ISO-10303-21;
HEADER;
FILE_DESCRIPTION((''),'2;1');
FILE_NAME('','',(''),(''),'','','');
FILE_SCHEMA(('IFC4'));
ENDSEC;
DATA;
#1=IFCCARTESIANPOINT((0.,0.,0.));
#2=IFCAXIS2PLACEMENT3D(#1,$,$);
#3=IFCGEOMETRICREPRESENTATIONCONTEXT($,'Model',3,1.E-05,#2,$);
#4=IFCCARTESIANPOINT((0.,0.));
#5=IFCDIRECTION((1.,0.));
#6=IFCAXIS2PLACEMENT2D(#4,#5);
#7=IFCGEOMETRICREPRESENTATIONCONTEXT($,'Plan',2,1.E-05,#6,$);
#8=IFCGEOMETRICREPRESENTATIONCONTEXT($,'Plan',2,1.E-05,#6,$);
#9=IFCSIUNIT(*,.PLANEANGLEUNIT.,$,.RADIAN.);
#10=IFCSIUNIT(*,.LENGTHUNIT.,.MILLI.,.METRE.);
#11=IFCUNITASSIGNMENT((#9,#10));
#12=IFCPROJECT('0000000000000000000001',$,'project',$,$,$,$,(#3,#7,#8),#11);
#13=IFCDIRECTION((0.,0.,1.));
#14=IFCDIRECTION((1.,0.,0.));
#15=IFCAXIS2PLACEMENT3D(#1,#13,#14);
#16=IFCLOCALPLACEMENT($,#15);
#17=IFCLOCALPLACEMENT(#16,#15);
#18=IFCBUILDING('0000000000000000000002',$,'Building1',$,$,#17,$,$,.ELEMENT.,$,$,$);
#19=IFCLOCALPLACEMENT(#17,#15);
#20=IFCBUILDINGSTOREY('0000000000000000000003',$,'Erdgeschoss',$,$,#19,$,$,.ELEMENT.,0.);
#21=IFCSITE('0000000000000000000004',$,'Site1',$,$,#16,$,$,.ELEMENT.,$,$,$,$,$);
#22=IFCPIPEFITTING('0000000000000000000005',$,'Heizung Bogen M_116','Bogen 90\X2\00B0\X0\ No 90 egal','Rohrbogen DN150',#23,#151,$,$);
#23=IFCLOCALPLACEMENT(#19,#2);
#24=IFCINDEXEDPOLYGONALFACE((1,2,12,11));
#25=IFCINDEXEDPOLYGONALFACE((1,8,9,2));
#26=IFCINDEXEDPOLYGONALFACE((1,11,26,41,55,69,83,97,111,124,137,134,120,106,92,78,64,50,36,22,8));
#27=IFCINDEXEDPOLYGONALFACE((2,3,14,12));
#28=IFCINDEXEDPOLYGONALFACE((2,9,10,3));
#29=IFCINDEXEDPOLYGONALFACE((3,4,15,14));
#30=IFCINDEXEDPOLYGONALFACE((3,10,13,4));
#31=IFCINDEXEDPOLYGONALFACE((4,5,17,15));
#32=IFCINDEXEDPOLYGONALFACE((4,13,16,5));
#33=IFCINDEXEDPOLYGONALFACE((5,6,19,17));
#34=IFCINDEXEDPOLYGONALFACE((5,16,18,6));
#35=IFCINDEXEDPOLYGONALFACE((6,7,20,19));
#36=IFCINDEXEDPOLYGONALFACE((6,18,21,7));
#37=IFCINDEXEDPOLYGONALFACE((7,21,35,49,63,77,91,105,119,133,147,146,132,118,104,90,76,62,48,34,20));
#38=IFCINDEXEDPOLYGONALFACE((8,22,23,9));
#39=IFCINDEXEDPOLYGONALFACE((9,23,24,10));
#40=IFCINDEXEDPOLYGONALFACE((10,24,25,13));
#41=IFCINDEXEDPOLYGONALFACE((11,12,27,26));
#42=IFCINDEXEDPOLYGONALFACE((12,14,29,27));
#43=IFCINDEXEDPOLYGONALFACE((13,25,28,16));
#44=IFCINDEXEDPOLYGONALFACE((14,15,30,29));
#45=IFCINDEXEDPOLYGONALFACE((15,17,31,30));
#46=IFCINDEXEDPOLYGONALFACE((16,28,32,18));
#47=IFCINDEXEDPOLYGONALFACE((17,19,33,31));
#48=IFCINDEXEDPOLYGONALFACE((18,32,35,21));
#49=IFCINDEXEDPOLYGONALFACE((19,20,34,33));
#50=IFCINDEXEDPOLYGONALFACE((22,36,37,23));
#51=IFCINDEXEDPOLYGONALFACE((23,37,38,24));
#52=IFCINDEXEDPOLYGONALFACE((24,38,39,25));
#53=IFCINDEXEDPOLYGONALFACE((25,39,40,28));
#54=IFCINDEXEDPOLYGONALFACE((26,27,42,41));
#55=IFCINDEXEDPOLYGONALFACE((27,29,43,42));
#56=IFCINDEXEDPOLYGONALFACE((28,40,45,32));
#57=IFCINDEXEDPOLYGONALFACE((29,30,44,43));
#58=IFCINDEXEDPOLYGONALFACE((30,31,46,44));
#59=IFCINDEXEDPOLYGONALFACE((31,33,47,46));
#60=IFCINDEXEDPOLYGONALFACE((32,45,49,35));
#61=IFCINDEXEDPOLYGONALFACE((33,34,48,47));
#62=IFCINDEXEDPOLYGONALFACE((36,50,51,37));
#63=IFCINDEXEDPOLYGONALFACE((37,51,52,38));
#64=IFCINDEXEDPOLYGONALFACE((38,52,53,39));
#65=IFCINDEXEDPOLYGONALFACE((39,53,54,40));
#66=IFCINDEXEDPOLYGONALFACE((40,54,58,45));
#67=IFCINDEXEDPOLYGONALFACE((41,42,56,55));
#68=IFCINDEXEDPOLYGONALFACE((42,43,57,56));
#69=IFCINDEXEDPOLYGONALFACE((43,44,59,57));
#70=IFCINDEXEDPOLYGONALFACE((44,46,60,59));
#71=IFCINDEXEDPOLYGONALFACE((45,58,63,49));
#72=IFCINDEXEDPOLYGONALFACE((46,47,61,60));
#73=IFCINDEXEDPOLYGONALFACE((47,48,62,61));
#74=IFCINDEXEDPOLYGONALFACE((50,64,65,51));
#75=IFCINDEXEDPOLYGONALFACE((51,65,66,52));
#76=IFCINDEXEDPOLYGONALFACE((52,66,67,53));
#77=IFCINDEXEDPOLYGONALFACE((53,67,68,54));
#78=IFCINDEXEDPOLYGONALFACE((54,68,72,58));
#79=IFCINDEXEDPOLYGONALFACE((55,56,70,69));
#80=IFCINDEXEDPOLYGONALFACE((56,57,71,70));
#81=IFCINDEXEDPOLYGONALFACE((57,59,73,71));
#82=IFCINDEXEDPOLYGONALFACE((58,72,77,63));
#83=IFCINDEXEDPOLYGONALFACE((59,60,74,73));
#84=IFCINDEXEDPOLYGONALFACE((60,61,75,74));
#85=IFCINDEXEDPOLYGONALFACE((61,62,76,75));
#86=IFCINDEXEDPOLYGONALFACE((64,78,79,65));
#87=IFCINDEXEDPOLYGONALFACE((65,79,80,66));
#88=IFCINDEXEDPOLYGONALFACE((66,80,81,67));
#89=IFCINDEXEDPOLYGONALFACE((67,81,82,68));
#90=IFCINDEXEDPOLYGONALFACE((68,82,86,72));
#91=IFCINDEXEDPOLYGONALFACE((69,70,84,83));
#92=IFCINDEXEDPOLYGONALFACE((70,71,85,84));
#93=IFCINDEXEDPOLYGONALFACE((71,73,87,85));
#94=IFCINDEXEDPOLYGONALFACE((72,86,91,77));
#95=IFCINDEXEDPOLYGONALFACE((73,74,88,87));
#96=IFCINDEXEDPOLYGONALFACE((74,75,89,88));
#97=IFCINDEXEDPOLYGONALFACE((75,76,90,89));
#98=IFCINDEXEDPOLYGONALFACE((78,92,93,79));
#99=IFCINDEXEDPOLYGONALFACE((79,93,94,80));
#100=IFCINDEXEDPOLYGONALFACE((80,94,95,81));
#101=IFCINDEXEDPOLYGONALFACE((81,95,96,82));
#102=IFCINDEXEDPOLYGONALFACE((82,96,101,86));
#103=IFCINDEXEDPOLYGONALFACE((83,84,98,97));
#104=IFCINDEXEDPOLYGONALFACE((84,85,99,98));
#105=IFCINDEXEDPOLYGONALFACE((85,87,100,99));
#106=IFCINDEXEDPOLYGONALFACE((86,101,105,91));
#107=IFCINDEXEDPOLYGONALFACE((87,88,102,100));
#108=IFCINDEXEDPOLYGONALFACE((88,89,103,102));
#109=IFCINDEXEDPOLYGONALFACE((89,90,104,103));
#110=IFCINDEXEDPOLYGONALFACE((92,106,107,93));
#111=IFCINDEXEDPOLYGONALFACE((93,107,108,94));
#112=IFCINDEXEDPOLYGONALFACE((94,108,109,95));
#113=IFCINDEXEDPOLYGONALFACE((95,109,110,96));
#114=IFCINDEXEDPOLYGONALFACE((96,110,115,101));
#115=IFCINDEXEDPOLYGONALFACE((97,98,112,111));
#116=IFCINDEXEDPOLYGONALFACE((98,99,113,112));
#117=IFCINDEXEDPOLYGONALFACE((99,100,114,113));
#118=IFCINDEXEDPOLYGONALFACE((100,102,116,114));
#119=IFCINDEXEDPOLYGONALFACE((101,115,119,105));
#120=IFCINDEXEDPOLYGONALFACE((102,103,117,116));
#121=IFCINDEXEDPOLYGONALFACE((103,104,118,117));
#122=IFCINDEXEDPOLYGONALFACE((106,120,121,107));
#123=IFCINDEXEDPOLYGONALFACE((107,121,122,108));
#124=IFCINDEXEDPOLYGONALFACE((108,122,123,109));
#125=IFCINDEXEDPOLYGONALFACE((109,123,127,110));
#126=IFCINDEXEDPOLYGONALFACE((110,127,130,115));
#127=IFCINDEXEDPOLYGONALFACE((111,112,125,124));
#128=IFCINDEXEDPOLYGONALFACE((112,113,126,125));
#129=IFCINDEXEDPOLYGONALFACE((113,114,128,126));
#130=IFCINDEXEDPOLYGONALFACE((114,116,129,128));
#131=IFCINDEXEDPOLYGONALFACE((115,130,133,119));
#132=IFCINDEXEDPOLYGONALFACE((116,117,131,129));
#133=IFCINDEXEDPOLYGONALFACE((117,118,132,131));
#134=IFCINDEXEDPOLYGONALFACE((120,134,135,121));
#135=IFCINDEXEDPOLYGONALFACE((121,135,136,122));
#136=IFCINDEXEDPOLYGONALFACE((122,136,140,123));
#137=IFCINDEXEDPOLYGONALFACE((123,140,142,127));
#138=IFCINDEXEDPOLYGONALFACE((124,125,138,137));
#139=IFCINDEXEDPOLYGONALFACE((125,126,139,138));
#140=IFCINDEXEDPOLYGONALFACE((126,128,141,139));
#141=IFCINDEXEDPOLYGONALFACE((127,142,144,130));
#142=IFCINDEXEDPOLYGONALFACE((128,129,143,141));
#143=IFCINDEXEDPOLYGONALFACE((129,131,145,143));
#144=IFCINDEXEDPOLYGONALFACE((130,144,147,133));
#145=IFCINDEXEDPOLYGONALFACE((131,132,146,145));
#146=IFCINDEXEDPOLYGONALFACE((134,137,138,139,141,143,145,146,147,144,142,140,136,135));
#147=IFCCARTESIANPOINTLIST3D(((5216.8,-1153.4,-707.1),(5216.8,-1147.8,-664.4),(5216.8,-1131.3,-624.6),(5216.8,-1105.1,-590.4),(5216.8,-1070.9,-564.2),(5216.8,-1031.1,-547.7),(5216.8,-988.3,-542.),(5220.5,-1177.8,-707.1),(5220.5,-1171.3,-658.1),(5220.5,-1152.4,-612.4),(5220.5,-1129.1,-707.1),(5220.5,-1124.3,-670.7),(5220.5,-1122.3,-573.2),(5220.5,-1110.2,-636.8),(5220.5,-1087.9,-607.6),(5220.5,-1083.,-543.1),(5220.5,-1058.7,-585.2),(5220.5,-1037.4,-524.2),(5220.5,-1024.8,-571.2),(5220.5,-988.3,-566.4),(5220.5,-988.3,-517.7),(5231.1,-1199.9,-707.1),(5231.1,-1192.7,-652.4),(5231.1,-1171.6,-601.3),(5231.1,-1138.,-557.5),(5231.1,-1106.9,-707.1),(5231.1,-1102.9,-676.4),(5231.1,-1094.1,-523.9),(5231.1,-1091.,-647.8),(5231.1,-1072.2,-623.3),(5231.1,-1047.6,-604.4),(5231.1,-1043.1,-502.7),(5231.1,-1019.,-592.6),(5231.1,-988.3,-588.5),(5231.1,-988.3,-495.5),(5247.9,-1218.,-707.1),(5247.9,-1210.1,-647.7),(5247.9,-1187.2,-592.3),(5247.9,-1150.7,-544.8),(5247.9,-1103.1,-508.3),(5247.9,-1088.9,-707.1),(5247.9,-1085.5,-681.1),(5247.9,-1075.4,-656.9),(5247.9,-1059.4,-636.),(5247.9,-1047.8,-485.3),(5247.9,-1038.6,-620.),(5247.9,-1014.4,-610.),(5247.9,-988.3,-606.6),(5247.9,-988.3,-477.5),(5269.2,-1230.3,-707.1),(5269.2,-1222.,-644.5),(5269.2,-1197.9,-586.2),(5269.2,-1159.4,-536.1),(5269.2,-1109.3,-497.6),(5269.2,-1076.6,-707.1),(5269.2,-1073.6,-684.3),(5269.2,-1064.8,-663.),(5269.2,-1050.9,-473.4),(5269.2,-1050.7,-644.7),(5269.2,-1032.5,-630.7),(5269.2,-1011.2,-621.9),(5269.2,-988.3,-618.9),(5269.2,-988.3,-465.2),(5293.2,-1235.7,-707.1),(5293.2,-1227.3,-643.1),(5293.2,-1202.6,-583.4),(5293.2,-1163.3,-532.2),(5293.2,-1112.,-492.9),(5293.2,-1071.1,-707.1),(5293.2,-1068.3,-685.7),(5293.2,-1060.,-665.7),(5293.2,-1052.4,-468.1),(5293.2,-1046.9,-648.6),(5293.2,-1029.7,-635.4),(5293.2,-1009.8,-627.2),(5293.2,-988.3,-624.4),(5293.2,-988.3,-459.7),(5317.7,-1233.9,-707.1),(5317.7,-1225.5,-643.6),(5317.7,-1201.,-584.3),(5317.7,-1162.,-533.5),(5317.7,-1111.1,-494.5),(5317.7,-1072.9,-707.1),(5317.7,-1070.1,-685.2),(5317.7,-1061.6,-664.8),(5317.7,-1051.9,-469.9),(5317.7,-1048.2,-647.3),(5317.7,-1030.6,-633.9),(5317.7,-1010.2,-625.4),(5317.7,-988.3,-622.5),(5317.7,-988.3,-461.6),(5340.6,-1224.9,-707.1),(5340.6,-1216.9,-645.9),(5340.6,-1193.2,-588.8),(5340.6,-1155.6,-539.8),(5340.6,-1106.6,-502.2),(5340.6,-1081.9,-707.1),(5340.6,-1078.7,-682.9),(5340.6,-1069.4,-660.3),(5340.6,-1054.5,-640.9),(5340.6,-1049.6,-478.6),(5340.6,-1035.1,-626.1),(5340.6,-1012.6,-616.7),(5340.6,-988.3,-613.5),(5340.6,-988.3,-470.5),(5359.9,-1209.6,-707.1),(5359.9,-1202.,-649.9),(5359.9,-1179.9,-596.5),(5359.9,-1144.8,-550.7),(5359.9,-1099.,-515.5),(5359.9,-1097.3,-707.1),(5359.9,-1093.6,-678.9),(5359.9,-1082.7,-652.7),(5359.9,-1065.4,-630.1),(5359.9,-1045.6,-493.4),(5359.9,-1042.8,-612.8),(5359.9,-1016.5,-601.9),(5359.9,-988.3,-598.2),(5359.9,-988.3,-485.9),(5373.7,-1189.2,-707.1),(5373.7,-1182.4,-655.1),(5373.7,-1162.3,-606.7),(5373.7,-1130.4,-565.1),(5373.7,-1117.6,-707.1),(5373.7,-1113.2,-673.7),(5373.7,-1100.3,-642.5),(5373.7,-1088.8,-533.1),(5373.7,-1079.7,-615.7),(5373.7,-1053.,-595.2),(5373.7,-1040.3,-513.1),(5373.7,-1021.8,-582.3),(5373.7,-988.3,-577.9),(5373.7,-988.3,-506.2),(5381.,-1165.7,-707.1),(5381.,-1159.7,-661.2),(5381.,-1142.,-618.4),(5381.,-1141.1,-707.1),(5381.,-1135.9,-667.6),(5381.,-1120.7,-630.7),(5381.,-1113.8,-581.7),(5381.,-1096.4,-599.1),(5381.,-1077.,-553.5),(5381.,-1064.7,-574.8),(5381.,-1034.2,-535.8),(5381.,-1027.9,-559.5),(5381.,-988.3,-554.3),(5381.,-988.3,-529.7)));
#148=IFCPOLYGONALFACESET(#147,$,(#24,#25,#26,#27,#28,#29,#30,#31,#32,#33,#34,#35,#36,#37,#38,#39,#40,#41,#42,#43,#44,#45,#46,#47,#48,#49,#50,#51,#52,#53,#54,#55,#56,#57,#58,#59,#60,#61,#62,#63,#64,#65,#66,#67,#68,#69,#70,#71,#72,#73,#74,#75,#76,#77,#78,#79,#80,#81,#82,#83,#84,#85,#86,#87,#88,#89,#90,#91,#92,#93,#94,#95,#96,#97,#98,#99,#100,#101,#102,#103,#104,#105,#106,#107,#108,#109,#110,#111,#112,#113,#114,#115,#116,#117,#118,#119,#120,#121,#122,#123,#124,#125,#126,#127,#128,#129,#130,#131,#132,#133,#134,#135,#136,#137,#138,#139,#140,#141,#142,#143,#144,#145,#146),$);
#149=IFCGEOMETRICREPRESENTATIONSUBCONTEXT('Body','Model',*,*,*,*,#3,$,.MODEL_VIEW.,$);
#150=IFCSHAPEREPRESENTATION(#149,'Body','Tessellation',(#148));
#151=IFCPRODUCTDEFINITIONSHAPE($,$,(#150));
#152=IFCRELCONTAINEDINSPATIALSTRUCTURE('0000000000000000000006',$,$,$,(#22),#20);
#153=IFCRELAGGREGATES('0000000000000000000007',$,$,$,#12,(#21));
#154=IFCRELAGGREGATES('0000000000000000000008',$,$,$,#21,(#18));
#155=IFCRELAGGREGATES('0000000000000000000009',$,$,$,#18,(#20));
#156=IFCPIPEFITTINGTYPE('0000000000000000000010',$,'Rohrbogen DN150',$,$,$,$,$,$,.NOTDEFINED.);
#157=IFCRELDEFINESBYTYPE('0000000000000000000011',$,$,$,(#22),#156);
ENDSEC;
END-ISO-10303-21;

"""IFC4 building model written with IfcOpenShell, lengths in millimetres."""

from ifc_helpers import new_model, entity, si_unit, frame, origin, origin_with_axes, origin_2d_with_axis, place, context, subcontext, project, spatial, source, transform, mapped, type_object, element, save


model = new_model("IFC4")

# Units and contexts
model_context = context("Model", 3, precision=1e-05, world=origin())
plan_context_1 = context("Plan", 2, precision=1e-05, world=origin_2d_with_axis())
plan_context_2 = context("Plan", 2, precision=1e-05, world=origin_2d_with_axis())
body_context = subcontext(model_context, "Body", "Model", "MODEL_VIEW")
ifc_project = project(units=[si_unit("PLANEANGLEUNIT", "RADIAN"), si_unit("LENGTHUNIT", "METRE", prefix="MILLI")], contexts=[model_context, plan_context_1, plan_context_2])

# Site, building, storey
site_placement = place(None, origin_with_axes())
site = spatial("IfcSite", under=ifc_project, at=site_placement, Name="Site1", CompositionType="ELEMENT")
building_placement = place(site_placement, origin_with_axes())
building = spatial("IfcBuilding", under=site, at=building_placement, Name="Building1", CompositionType="ELEMENT")
storey_placement = place(building_placement, origin_with_axes())
storey = spatial("IfcBuildingStorey", under=building, at=storey_placement, Name="Erdgeschoss", CompositionType="ELEMENT", Elevation=0.0)

# Pipe fitting
pipe_fitting_type_1 = type_object("IfcPipeFittingType", Name="Rohrbogen DN150", PredefinedType="NOTDEFINED")
shared_shape_1 = source(origin_with_axes(), body_context, "Body", "SolidModel", [
    entity("IfcRevolvedAreaSolid", entity("IfcCircleProfileDef", "AREA", None, entity("IfcAxis2Placement2D", entity("IfcCartesianPoint", [0.0, 0.0]), entity("IfcDirection", [1.0, 0.0])), 82.5), entity("IfcAxis2Placement3D", entity("IfcCartesianPoint", [-123.8, 0.0, 41.3]), entity("IfcDirection", [1.0, 0.0, 0.0]), entity("IfcDirection", [0.0, -1.0, 0.0])), entity("IfcAxis1Placement", entity("IfcCartesianPoint", [0.0, 165.1, 0.0]), entity("IfcDirection", [-1.0, 0.0, 0.0])), 1.570796),
])
pipe_fitting_1_placement = place(storey_placement, frame((5299.4, -1112.2, -583.3), z_axis=(0.0, 0.0, 1.0), x_axis=(1.0, 0.0, 0.0)))
element("IfcPipeFitting", 1, at=pipe_fitting_1_placement, inside=storey, type_object=pipe_fitting_type_1, Name="Heizung Bogen M_116", Description="Bogen 90° No 90 egal", ObjectType="Rohrbogen DN150", context=body_context, shape_type="MappedRepresentation", body=[
    mapped(shared_shape_1, transform((0.0, 0.0, 0.0), x_axis=(0.0, -1.0, 0.0), y_axis=(1.0, 0.0, 0.0), z_axis=(0.0, 0.0, 1.0), scale=1.0)),
])

save(model, "model.ifc")
